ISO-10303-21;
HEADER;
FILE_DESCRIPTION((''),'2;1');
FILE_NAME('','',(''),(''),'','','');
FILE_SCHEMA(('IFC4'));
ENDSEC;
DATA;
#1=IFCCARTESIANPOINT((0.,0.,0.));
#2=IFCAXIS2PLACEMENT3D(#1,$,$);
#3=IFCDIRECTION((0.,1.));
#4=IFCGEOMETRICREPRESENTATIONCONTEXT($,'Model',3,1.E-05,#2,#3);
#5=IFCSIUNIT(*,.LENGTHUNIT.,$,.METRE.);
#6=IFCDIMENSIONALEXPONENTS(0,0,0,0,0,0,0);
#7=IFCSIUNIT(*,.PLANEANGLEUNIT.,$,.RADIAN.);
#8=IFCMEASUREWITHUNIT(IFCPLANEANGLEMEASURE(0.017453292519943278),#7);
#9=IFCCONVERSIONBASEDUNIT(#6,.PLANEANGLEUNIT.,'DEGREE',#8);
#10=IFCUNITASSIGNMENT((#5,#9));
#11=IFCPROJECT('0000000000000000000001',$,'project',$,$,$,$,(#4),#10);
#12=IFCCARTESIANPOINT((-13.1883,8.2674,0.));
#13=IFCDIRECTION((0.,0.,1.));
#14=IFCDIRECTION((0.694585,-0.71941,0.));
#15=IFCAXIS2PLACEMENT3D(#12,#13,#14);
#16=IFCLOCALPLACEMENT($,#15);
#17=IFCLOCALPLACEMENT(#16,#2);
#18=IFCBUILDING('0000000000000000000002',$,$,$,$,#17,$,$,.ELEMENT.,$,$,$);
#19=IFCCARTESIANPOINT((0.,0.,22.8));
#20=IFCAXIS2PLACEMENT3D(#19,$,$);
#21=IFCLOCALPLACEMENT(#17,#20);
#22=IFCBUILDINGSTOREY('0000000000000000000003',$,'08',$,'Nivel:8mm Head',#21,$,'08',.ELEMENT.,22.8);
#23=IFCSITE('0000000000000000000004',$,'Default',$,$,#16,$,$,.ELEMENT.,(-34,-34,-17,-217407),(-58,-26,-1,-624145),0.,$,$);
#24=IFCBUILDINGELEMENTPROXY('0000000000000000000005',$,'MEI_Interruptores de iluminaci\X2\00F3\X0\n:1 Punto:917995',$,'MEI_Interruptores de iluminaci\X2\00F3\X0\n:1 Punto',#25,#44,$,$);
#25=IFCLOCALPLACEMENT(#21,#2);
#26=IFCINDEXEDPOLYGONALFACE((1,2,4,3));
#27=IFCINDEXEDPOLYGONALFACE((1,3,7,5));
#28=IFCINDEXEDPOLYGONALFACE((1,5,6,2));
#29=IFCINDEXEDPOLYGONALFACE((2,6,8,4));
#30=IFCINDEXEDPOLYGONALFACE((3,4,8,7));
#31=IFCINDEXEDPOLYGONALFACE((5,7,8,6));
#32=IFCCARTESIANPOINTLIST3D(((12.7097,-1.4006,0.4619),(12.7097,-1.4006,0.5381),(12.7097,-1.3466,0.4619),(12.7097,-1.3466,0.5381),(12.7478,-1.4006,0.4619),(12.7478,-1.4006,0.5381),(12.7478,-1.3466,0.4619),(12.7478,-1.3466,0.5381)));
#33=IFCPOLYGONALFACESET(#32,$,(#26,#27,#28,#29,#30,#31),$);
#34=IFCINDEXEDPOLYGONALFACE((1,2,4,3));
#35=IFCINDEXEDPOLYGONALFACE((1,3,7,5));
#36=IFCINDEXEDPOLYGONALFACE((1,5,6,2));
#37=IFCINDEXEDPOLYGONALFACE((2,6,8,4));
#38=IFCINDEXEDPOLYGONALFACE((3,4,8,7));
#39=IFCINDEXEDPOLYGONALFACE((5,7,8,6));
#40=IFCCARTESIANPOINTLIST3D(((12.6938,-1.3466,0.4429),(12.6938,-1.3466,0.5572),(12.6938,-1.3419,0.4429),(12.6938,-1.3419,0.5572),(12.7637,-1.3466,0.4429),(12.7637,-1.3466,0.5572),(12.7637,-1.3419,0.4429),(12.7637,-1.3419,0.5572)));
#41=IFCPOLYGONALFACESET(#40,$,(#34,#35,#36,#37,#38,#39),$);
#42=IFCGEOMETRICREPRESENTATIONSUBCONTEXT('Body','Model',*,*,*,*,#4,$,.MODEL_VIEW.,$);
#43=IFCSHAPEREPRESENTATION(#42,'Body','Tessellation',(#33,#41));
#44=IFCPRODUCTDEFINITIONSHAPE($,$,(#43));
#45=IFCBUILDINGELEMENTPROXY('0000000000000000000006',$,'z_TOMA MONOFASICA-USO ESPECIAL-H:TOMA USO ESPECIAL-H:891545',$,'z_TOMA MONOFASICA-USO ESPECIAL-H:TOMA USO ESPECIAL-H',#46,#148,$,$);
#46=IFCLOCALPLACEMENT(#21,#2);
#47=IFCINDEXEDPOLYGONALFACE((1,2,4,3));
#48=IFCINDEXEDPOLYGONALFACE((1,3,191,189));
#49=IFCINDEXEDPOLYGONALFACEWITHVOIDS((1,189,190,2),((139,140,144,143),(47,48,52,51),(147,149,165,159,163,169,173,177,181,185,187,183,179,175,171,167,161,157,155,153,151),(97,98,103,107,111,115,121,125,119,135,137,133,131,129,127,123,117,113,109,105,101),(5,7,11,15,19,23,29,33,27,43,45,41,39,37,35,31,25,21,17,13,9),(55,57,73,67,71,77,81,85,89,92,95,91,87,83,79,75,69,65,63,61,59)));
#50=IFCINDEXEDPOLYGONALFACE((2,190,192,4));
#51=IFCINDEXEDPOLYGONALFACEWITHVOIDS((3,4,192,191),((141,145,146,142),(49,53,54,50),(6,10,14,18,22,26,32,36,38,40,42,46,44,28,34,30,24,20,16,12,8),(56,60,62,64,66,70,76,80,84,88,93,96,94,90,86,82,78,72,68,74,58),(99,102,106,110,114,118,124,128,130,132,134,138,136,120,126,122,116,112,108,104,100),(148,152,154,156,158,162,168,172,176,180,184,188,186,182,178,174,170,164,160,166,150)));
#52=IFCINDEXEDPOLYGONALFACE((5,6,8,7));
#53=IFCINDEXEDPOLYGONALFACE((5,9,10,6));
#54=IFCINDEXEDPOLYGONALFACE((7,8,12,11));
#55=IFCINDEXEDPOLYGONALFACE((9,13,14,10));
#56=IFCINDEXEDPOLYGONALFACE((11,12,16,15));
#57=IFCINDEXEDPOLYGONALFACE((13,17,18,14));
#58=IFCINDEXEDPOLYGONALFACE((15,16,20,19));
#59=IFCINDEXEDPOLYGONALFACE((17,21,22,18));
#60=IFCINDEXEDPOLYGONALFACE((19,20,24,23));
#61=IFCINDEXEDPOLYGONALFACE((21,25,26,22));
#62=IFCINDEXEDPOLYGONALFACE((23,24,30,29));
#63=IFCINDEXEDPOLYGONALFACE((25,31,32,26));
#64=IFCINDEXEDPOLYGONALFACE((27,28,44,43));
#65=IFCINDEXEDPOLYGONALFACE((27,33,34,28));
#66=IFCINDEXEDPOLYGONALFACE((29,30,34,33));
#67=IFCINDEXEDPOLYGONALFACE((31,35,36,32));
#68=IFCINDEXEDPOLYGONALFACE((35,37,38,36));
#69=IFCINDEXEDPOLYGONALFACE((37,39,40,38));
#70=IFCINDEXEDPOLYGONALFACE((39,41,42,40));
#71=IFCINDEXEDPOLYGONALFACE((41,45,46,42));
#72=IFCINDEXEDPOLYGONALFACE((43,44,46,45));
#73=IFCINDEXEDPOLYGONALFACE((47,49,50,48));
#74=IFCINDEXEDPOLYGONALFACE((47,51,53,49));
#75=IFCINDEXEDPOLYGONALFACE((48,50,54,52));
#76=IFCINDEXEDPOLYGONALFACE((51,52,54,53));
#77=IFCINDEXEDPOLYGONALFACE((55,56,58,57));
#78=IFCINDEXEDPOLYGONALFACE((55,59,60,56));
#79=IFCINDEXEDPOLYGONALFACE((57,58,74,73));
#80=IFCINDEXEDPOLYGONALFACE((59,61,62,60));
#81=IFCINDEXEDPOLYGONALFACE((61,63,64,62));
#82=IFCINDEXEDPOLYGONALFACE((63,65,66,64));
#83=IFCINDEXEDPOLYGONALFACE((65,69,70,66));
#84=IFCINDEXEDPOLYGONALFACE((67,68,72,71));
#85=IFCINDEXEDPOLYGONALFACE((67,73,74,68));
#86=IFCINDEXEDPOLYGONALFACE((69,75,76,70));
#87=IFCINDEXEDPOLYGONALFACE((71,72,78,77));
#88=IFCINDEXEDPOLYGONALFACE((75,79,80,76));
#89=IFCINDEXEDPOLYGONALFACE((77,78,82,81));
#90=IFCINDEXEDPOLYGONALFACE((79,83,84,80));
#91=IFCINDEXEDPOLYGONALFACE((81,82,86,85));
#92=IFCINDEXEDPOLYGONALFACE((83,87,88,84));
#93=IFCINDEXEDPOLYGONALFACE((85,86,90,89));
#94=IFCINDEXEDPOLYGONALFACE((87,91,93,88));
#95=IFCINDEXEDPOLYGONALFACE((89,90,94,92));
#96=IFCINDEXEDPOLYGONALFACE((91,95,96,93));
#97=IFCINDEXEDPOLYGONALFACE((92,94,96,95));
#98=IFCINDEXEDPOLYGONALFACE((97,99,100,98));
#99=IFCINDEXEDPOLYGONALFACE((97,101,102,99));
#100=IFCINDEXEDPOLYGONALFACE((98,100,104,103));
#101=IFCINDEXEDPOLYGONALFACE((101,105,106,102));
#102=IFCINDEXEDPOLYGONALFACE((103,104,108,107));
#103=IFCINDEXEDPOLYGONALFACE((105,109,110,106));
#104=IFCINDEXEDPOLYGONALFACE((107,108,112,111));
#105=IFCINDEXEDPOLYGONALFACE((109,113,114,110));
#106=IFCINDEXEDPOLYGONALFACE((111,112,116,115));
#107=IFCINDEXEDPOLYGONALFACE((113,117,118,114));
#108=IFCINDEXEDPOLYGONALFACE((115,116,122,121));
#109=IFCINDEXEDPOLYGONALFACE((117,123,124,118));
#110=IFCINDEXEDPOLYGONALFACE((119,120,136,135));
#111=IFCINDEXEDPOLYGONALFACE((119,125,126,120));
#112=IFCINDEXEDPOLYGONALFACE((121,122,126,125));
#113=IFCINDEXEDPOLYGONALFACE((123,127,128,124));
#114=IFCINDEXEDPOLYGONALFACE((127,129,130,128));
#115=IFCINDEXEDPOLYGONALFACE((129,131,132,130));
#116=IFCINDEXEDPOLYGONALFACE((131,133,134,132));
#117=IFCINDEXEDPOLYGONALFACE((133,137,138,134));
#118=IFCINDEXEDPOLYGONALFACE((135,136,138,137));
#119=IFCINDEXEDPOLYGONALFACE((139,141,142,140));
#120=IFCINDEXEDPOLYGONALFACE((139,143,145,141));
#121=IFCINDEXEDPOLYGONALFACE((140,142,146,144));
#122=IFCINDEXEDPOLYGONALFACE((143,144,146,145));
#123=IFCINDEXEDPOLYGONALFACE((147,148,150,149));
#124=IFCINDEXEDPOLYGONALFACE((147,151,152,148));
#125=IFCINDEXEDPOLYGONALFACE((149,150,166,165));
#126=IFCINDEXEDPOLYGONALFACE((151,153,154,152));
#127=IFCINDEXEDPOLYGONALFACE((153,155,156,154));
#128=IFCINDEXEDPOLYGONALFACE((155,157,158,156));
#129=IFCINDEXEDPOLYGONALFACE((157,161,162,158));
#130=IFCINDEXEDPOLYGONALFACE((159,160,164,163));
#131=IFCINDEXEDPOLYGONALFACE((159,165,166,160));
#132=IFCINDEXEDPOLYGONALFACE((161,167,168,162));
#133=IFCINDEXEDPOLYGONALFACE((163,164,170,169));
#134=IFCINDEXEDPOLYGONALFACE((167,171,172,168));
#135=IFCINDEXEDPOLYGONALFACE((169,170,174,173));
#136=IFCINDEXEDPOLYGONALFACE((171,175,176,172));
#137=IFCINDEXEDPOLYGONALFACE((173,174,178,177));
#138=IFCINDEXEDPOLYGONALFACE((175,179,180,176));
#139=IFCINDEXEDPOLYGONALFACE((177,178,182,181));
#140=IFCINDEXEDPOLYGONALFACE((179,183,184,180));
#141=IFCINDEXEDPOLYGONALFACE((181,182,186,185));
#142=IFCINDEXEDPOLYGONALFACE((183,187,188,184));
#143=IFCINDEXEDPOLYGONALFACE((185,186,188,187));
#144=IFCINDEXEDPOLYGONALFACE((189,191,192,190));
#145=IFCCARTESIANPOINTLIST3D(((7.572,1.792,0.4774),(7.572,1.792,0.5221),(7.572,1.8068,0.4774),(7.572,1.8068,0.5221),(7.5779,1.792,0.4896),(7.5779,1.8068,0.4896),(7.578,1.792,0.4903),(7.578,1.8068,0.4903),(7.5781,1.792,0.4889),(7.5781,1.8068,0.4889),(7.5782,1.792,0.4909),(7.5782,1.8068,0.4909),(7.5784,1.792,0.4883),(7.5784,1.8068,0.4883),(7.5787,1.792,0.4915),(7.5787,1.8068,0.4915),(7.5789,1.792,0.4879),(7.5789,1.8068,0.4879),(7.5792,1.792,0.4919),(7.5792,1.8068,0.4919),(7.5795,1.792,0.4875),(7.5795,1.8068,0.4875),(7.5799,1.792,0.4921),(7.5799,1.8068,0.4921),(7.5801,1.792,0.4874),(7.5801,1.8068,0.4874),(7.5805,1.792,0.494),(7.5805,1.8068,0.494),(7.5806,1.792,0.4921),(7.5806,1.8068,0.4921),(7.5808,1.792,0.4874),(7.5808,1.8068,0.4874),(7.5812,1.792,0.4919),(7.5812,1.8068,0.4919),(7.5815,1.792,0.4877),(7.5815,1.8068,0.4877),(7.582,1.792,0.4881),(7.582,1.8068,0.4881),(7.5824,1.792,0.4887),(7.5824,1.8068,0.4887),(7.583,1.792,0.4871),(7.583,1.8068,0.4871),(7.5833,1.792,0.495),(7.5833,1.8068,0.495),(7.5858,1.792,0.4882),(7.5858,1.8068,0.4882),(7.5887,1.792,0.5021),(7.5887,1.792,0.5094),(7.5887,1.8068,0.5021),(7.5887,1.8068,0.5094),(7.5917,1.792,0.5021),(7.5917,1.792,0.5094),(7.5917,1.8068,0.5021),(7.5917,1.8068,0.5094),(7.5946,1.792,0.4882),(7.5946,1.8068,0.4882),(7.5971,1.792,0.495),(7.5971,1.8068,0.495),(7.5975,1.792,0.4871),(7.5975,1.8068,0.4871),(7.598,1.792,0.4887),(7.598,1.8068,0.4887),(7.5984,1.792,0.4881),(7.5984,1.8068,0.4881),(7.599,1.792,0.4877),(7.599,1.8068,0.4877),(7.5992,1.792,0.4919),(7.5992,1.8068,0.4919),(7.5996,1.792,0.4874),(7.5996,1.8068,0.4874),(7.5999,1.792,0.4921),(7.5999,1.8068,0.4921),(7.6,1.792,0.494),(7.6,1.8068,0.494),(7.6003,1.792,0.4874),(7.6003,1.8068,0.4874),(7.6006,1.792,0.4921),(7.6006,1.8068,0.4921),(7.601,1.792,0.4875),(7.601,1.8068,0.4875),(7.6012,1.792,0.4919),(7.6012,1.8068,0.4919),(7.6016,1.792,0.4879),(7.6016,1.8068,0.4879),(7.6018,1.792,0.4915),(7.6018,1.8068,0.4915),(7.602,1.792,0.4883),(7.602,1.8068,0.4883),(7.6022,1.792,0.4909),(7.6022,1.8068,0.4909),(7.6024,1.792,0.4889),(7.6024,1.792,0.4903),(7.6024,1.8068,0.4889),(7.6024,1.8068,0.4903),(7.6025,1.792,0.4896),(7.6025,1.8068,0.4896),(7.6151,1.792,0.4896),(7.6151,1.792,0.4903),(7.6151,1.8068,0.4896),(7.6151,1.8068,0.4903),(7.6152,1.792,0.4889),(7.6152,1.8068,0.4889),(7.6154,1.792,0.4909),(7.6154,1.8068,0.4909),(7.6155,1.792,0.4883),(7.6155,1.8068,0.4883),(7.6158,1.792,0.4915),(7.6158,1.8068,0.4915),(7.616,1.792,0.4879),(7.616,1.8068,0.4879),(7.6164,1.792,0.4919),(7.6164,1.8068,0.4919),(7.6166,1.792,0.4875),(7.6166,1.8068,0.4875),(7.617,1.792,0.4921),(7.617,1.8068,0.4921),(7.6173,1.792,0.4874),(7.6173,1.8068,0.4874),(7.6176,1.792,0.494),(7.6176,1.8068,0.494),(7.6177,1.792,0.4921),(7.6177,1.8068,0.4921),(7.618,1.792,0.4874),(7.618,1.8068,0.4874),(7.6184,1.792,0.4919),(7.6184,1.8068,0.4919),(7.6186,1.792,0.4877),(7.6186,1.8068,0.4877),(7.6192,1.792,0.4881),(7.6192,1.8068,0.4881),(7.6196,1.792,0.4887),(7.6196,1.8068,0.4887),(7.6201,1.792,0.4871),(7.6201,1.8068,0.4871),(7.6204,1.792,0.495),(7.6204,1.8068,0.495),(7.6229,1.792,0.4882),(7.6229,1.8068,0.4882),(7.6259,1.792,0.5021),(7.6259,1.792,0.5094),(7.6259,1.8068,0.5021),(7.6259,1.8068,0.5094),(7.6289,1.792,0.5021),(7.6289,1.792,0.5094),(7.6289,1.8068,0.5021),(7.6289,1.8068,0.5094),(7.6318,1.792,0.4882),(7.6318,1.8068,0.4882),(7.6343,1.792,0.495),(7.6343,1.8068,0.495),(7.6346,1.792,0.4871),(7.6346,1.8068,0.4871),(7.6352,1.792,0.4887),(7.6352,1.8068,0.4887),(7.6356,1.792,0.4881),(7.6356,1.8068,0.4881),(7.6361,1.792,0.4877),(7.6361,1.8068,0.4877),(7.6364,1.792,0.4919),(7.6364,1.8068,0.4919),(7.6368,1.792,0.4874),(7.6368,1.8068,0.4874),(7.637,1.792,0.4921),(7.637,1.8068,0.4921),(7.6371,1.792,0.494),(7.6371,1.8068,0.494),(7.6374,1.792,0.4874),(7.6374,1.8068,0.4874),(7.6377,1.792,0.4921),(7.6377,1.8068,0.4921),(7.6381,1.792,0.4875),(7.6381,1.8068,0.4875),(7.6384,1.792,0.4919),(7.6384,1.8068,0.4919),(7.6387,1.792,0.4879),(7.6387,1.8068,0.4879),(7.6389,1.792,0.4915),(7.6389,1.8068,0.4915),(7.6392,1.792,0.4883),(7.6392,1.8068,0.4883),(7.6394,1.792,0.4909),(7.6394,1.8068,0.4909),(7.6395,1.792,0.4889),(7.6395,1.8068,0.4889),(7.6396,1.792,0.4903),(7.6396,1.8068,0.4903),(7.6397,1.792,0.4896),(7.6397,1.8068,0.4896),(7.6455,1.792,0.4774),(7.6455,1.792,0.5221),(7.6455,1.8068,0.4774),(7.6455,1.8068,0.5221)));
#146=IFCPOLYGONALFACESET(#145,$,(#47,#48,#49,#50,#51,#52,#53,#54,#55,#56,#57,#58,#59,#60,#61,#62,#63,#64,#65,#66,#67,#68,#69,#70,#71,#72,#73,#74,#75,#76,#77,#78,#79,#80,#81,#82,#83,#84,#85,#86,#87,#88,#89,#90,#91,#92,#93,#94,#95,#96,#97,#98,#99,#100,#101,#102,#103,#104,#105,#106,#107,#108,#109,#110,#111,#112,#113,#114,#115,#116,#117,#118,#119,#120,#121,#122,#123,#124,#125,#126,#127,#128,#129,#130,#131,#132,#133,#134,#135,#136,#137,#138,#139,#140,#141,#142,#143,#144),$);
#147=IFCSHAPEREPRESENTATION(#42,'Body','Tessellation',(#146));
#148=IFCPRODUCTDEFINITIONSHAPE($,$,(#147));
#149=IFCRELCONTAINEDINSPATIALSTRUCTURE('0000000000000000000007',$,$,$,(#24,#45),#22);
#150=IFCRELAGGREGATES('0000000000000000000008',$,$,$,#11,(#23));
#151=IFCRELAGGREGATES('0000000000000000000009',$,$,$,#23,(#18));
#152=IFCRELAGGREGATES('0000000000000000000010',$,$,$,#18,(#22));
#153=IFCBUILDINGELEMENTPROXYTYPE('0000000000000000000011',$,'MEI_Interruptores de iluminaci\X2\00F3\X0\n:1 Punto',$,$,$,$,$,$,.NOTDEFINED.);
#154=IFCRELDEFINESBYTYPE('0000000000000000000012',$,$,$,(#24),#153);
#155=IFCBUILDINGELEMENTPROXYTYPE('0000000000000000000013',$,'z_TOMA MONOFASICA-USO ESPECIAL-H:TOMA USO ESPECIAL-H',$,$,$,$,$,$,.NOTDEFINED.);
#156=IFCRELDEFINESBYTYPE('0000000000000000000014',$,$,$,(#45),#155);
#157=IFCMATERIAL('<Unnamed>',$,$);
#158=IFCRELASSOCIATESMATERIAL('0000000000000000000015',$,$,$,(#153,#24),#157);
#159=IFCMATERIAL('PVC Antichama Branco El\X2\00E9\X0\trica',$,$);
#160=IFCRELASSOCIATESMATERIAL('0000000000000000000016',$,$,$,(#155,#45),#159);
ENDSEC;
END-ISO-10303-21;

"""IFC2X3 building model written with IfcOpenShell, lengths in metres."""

from ifc_helpers import new_model, entity, si_unit, converted_unit, direction, frame, frame_2d, origin, origin_2d_with_axis, place, context, subcontext, project, spatial, polyline, circle_curve, parameter, trimmed, segment, composite_curve, rectangle, outline, extrude, source, transform, mapped, material, type_object, type_shapes, element, save


model = new_model("IFC2X3")

# Units and contexts
model_context = context("Model", 3, precision=1e-05, world=origin(), true_north=direction((0.0, 1.0)))
body_context = subcontext(model_context, "Body", "Model", "MODEL_VIEW")
ifc_project = project(units=[si_unit("LENGTHUNIT", "METRE"), converted_unit("PLANEANGLEUNIT", "DEGREE", entity("IfcPlaneAngleMeasure", 0.017453292519943278), si_unit("PLANEANGLEUNIT", "RADIAN"), dimensions=[0, 0, 0, 0, 0, 0, 0])], contexts=[model_context])

# Site, building, storey
site_placement = place(None, frame((-13.1883, 8.2674, 0.0), z_axis=(0.0, 0.0, 1.0), x_axis=(0.694585, -0.71941, 0.0)))
site = spatial("IfcSite", under=ifc_project, at=site_placement, Name="Default", CompositionType="ELEMENT", RefLatitude=(-34, -34, -17, -217407), RefLongitude=(-58, -26, -1, -624145), RefElevation=0.0)
building_placement = place(site_placement, origin())
building = spatial("IfcBuilding", under=site, at=building_placement, CompositionType="ELEMENT")
storey_placement = place(building_placement, frame((0.0, 0.0, 22.8)))
storey = spatial("IfcBuildingStorey", under=building, at=storey_placement, Name="08", ObjectType="Nivel:8mm Head", LongName="08", CompositionType="ELEMENT", Elevation=22.8)

# Building element proxies
ifc_material_1 = material(Name="<Unnamed>")
building_element_proxy_type_1 = type_object("IfcBuildingElementProxyType", Name="MEI_Interruptores de iluminación:1 Punto", PredefinedType="NOTDEFINED", material=ifc_material_1)
shared_shape_1 = source(origin(), body_context, "Body", "SweptSolid", [
    extrude(rectangle(XDim=0.0381, YDim=0.0762, at=origin_2d_with_axis()), frame((0.0, 0.0, -0.054), z_axis=(0.0, 0.0, 1.0), x_axis=(-1.0, 0.0, 0.0)), (0.0, 0.0, 1.0), 0.054),
    extrude(rectangle(XDim=0.0698, YDim=0.1143, at=frame_2d((0.0, 0.0), x_axis=(1.0, 0.0))), frame((0.0, 0.0, 0.0), z_axis=(0.0, 0.0, 1.0), x_axis=(-1.0, 0.0, 0.0)), (0.0, 0.0, 1.0), 0.0048),
])
type_shapes(building_element_proxy_type_1, [shared_shape_1])
for number, where, z_axis, x_axis, name in (
    (1, (12.7288, -1.3466, 0.5), (0.0, 1.0, 0.0), (-1.0, 0.0, 0.0), "MEI_Interruptores de iluminación:1 Punto:917995"),
):
    element("IfcBuildingElementProxy", number, at=place(storey_placement, frame(where, z_axis=z_axis, x_axis=x_axis)), inside=storey, type_object=building_element_proxy_type_1, material=ifc_material_1, Name=name, ObjectType="MEI_Interruptores de iluminación:1 Punto", context=body_context, shape_type="MappedRepresentation", body=[
        mapped(shared_shape_1, transform((0.0, 0.0, 0.0), scale=1.0)),
    ])
ifc_material_2 = material(Name="PVC Antichama Branco Elétrica")
building_element_proxy_type_2 = type_object("IfcBuildingElementProxyType", Name="z_TOMA MONOFASICA-USO ESPECIAL-H:TOMA USO ESPECIAL-H", PredefinedType="NOTDEFINED", material=ifc_material_2)
shared_shape_2 = source(origin(), body_context, "Body", "SweptSolid", [
    extrude(outline(polyline([(-0.0368, -0.0223), (0.0368, -0.0223), (0.0368, 0.0223), (-0.0368, 0.0223), (-0.0368, -0.0223)]), holes=[composite_curve([segment(polyline([(0.0141, 0.0115), (0.0116, 0.0047)]), True, "CONTINUOUS"), segment(polyline([(0.0116, 0.0047), (0.0088, 0.0057)]), True, "CONTINUOUS"), segment(polyline([(0.0088, 0.0057), (0.0096, 0.0078)]), True, "CONTINUOUS"), segment(trimmed(circle_curve(frame_2d((0.0087, 0.0099), x_axis=(1.0, 0.0)), 0.0024), [parameter(27.118901)], [parameter(292.881099)], True, "PARAMETER"), False, "CONTINUOUS"), segment(polyline([(0.0108, 0.011), (0.0113, 0.0126)]), True, "CONTINUOUS"), segment(polyline([(0.0113, 0.0126), (0.0141, 0.0115)]), True, "CONTINUOUS")], self_intersect=False), composite_curve([segment(polyline([(0.0255, 0.0047), (0.023, 0.0115)]), True, "CONTINUOUS"), segment(polyline([(0.023, 0.0115), (0.0258, 0.0126)]), True, "CONTINUOUS"), segment(polyline([(0.0258, 0.0126), (0.0264, 0.011)]), True, "CONTINUOUS"), segment(trimmed(circle_curve(frame_2d((0.0285, 0.0099), x_axis=(1.0, 0.0)), 0.0024), [parameter(247.118901)], [parameter(152.881099)], True, "PARAMETER"), False, "CONTINUOUS"), segment(polyline([(0.0276, 0.0078), (0.0283, 0.0057)]), True, "CONTINUOUS"), segment(polyline([(0.0283, 0.0057), (0.0255, 0.0047)]), True, "CONTINUOUS")], self_intersect=False), polyline([(0.0201, -0.0024), (0.0201, -0.0097), (0.0171, -0.0097), (0.0171, -0.0024), (0.0201, -0.0024)]), composite_curve([segment(polyline([(-0.0141, 0.0115), (-0.0113, 0.0126)]), True, "CONTINUOUS"), segment(polyline([(-0.0113, 0.0126), (-0.0108, 0.011)]), True, "CONTINUOUS"), segment(trimmed(circle_curve(frame_2d((-0.0087, 0.0099), x_axis=(1.0, 0.0)), 0.0024), [parameter(247.118901)], [parameter(152.881099)], True, "PARAMETER"), False, "CONTINUOUS"), segment(polyline([(-0.0096, 0.0078), (-0.0088, 0.0057)]), True, "CONTINUOUS"), segment(polyline([(-0.0088, 0.0057), (-0.0116, 0.0047)]), True, "CONTINUOUS"), segment(polyline([(-0.0116, 0.0047), (-0.0141, 0.0115)]), True, "CONTINUOUS")], self_intersect=False), composite_curve([segment(polyline([(-0.0255, 0.0047), (-0.0283, 0.0057)]), True, "CONTINUOUS"), segment(polyline([(-0.0283, 0.0057), (-0.0276, 0.0078)]), True, "CONTINUOUS"), segment(trimmed(circle_curve(frame_2d((-0.0285, 0.0099), x_axis=(1.0, 0.0)), 0.0024), [parameter(27.118901)], [parameter(292.881099)], True, "PARAMETER"), False, "CONTINUOUS"), segment(polyline([(-0.0264, 0.011), (-0.0258, 0.0126)]), True, "CONTINUOUS"), segment(polyline([(-0.0258, 0.0126), (-0.023, 0.0115)]), True, "CONTINUOUS"), segment(polyline([(-0.023, 0.0115), (-0.0255, 0.0047)]), True, "CONTINUOUS")], self_intersect=False), polyline([(-0.0201, -0.0024), (-0.0171, -0.0024), (-0.0171, -0.0097), (-0.0201, -0.0097), (-0.0201, -0.0024)])]), frame((0.0, -0.005, 0.0223), z_axis=(0.0, 1.0, 0.0), x_axis=(1.0, 0.0, 0.0)), (0.0, 0.0, 1.0), 0.0148),
])
type_shapes(building_element_proxy_type_2, [shared_shape_2])
for number, where, z_axis, x_axis, name in (
    (2, (7.6088, 1.8018, 0.4774), (0.0, 0.0, 1.0), (-1.0, 0.0, 0.0), "z_TOMA MONOFASICA-USO ESPECIAL-H:TOMA USO ESPECIAL-H:891545"),
):
    element("IfcBuildingElementProxy", number, at=place(storey_placement, frame(where, z_axis=z_axis, x_axis=x_axis)), inside=storey, type_object=building_element_proxy_type_2, material=ifc_material_2, Name=name, ObjectType="z_TOMA MONOFASICA-USO ESPECIAL-H:TOMA USO ESPECIAL-H", context=body_context, shape_type="MappedRepresentation", body=[
        mapped(shared_shape_2, transform((0.0, 0.0, 0.0), scale=1.0)),
    ])

save(model, "model.ifc")
